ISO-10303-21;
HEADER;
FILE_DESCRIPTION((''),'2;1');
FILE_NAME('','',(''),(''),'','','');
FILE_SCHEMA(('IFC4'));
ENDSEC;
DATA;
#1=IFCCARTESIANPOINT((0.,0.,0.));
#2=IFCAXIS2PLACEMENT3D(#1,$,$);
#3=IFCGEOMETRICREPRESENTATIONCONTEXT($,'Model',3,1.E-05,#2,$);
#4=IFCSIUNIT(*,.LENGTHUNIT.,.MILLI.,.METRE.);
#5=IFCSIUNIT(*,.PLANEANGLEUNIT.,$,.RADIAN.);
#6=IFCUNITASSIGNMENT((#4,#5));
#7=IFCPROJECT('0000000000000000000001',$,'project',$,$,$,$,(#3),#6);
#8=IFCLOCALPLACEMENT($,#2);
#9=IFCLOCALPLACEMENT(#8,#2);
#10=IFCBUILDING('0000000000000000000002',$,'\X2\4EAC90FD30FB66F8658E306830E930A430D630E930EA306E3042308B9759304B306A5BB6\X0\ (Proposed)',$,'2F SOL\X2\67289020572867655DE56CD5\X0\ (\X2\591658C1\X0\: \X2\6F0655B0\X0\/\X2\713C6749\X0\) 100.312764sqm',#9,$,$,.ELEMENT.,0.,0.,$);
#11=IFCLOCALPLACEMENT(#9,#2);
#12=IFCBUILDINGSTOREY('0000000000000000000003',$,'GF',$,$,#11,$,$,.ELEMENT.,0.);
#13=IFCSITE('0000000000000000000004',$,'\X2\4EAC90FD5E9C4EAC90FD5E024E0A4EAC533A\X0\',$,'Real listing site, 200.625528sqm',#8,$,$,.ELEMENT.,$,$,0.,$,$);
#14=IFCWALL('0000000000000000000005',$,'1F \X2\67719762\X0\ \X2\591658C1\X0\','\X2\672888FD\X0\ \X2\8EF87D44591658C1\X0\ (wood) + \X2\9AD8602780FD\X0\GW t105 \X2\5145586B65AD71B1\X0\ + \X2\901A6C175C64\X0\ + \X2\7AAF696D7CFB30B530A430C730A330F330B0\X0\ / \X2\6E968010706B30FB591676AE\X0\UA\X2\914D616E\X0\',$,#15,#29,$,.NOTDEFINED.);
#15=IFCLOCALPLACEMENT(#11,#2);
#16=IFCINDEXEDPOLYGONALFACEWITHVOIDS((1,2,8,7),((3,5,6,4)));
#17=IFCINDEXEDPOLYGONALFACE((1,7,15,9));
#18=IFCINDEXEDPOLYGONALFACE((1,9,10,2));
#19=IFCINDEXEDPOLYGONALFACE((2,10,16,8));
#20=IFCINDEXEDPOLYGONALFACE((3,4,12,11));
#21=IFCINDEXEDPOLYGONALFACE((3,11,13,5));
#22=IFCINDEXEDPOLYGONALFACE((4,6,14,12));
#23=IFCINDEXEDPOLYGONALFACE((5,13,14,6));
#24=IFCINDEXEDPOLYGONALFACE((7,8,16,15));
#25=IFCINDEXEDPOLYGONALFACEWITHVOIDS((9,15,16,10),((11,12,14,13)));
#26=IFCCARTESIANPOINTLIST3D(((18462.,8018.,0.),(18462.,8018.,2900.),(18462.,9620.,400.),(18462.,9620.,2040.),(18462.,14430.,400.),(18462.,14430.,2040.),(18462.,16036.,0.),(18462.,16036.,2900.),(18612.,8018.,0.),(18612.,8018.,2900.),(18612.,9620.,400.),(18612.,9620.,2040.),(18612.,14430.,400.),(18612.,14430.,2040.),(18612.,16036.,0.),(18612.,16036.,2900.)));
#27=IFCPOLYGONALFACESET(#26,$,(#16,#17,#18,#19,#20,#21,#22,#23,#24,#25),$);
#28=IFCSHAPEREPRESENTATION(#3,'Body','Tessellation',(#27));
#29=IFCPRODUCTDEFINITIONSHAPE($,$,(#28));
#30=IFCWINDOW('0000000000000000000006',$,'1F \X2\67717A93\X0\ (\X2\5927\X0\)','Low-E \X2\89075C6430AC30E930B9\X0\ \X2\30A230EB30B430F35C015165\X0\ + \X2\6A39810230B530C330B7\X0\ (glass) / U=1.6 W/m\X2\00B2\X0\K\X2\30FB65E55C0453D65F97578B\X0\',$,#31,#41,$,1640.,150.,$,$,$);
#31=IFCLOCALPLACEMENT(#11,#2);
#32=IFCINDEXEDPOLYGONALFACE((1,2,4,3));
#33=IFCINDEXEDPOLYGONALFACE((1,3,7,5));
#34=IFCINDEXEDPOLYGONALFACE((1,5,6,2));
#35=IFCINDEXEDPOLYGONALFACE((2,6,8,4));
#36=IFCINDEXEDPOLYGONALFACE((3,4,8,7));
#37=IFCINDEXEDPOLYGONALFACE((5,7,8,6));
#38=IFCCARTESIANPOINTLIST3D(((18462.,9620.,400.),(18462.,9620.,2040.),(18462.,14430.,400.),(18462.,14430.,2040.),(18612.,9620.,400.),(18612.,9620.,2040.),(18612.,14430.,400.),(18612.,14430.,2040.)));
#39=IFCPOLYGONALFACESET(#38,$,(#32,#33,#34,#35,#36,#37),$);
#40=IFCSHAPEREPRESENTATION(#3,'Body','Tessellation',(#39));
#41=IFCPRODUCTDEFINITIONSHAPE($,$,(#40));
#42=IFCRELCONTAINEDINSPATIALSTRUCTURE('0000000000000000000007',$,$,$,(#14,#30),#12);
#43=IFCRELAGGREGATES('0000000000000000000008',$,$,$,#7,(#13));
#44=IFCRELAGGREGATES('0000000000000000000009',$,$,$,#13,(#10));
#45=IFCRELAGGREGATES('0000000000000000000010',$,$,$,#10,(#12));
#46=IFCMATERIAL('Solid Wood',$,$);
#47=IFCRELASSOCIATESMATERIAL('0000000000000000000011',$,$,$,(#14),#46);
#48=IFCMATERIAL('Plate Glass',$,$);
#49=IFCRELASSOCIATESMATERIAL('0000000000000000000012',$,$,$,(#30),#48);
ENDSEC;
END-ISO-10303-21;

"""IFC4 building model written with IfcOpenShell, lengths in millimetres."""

from ifc_helpers import new_model, si_unit, frame, frame_2d, origin, place, context, project, spatial, rectangle, extrude, material, element, fill, save


model = new_model("IFC4")

# Units and contexts
model_context = context("Model", 3, precision=1e-05, world=origin())
ifc_project = project(units=[si_unit("LENGTHUNIT", "METRE", prefix="MILLI"), si_unit("PLANEANGLEUNIT", "RADIAN")], contexts=[model_context])

# Site, building, storey
site_placement = place(None, origin())
site = spatial("IfcSite", under=ifc_project, at=site_placement, Name="京都府京都市上京区", ObjectType="Real listing site, 200.625528sqm", CompositionType="ELEMENT", RefElevation=0.0)
building_placement = place(site_placement, origin())
building = spatial("IfcBuilding", under=site, at=building_placement, Name="京都・書斎とライブラリのある静かな家 (Proposed)", ObjectType="2F SOL木造在来工法 (外壁: 漆喰/焼杉) 100.312764sqm", CompositionType="ELEMENT", ElevationOfRefHeight=0.0, ElevationOfTerrain=0.0)
storey_placement = place(building_placement, origin())
storey = spatial("IfcBuildingStorey", under=building, at=storey_placement, Name="GF", CompositionType="ELEMENT", Elevation=0.0)

# Wall, opening, window
ifc_material_1 = material(Name="Solid Wood")
wall_1_placement = place(storey_placement, frame((9231.0, 4009.0, 0.0)))
wall_1 = element("IfcWall", 1, at=wall_1_placement, inside=storey, material=ifc_material_1, Name="1F 東面 外壁", Description="木製 軸組外壁 (wood) + 高性能GW t105 充填断熱 + 通気層 + 窯業系サイディング / 準耐火・外皮UA配慮", PredefinedType="NOTDEFINED", context=model_context, shape_type="SweptSolid", body=[
    extrude(rectangle(XDim=150.0, YDim=8018.0, at=frame_2d((75.0, 4009.0))), frame((9231.0, 4009.0, 0.0)), (0.0, 0.0, 1.0), 2900.0),
])
opening_1_placement = place(storey_placement, frame((9231.0, 4810.0, 200.0)))
opening_1 = element("IfcOpeningElement", 2, at=opening_1_placement, cuts=wall_1, PredefinedType="NOTDEFINED", context=model_context, shape_type="SweptSolid", body=[
    extrude(rectangle(XDim=150.0, YDim=4810.0, at=frame_2d((75.0, 2405.0))), frame((9231.0, 4810.0, 200.0)), (0.0, 0.0, 1.0), 1640.0),
])
ifc_material_2 = material(Name="Plate Glass")
window_1_placement = place(storey_placement, frame((9231.0, 4810.0, 200.0)))
window_1 = element("IfcWindow", 3, at=window_1_placement, inside=storey, material=ifc_material_2, Name="1F 東窓 (大)", Description="Low-E 複層ガラス アルゴン封入 + 樹脂サッシ (glass) / U=1.6 W/m²K・日射取得型", OverallHeight=1640.0, OverallWidth=150.0, context=model_context, shape_type="SweptSolid", body=[
    extrude(rectangle(XDim=150.0, YDim=4810.0, at=frame_2d((75.0, 2405.0))), frame((9231.0, 4810.0, 200.0)), (0.0, 0.0, 1.0), 1640.0),
])
fill(opening_1, window_1)

save(model, "model.ifc")
